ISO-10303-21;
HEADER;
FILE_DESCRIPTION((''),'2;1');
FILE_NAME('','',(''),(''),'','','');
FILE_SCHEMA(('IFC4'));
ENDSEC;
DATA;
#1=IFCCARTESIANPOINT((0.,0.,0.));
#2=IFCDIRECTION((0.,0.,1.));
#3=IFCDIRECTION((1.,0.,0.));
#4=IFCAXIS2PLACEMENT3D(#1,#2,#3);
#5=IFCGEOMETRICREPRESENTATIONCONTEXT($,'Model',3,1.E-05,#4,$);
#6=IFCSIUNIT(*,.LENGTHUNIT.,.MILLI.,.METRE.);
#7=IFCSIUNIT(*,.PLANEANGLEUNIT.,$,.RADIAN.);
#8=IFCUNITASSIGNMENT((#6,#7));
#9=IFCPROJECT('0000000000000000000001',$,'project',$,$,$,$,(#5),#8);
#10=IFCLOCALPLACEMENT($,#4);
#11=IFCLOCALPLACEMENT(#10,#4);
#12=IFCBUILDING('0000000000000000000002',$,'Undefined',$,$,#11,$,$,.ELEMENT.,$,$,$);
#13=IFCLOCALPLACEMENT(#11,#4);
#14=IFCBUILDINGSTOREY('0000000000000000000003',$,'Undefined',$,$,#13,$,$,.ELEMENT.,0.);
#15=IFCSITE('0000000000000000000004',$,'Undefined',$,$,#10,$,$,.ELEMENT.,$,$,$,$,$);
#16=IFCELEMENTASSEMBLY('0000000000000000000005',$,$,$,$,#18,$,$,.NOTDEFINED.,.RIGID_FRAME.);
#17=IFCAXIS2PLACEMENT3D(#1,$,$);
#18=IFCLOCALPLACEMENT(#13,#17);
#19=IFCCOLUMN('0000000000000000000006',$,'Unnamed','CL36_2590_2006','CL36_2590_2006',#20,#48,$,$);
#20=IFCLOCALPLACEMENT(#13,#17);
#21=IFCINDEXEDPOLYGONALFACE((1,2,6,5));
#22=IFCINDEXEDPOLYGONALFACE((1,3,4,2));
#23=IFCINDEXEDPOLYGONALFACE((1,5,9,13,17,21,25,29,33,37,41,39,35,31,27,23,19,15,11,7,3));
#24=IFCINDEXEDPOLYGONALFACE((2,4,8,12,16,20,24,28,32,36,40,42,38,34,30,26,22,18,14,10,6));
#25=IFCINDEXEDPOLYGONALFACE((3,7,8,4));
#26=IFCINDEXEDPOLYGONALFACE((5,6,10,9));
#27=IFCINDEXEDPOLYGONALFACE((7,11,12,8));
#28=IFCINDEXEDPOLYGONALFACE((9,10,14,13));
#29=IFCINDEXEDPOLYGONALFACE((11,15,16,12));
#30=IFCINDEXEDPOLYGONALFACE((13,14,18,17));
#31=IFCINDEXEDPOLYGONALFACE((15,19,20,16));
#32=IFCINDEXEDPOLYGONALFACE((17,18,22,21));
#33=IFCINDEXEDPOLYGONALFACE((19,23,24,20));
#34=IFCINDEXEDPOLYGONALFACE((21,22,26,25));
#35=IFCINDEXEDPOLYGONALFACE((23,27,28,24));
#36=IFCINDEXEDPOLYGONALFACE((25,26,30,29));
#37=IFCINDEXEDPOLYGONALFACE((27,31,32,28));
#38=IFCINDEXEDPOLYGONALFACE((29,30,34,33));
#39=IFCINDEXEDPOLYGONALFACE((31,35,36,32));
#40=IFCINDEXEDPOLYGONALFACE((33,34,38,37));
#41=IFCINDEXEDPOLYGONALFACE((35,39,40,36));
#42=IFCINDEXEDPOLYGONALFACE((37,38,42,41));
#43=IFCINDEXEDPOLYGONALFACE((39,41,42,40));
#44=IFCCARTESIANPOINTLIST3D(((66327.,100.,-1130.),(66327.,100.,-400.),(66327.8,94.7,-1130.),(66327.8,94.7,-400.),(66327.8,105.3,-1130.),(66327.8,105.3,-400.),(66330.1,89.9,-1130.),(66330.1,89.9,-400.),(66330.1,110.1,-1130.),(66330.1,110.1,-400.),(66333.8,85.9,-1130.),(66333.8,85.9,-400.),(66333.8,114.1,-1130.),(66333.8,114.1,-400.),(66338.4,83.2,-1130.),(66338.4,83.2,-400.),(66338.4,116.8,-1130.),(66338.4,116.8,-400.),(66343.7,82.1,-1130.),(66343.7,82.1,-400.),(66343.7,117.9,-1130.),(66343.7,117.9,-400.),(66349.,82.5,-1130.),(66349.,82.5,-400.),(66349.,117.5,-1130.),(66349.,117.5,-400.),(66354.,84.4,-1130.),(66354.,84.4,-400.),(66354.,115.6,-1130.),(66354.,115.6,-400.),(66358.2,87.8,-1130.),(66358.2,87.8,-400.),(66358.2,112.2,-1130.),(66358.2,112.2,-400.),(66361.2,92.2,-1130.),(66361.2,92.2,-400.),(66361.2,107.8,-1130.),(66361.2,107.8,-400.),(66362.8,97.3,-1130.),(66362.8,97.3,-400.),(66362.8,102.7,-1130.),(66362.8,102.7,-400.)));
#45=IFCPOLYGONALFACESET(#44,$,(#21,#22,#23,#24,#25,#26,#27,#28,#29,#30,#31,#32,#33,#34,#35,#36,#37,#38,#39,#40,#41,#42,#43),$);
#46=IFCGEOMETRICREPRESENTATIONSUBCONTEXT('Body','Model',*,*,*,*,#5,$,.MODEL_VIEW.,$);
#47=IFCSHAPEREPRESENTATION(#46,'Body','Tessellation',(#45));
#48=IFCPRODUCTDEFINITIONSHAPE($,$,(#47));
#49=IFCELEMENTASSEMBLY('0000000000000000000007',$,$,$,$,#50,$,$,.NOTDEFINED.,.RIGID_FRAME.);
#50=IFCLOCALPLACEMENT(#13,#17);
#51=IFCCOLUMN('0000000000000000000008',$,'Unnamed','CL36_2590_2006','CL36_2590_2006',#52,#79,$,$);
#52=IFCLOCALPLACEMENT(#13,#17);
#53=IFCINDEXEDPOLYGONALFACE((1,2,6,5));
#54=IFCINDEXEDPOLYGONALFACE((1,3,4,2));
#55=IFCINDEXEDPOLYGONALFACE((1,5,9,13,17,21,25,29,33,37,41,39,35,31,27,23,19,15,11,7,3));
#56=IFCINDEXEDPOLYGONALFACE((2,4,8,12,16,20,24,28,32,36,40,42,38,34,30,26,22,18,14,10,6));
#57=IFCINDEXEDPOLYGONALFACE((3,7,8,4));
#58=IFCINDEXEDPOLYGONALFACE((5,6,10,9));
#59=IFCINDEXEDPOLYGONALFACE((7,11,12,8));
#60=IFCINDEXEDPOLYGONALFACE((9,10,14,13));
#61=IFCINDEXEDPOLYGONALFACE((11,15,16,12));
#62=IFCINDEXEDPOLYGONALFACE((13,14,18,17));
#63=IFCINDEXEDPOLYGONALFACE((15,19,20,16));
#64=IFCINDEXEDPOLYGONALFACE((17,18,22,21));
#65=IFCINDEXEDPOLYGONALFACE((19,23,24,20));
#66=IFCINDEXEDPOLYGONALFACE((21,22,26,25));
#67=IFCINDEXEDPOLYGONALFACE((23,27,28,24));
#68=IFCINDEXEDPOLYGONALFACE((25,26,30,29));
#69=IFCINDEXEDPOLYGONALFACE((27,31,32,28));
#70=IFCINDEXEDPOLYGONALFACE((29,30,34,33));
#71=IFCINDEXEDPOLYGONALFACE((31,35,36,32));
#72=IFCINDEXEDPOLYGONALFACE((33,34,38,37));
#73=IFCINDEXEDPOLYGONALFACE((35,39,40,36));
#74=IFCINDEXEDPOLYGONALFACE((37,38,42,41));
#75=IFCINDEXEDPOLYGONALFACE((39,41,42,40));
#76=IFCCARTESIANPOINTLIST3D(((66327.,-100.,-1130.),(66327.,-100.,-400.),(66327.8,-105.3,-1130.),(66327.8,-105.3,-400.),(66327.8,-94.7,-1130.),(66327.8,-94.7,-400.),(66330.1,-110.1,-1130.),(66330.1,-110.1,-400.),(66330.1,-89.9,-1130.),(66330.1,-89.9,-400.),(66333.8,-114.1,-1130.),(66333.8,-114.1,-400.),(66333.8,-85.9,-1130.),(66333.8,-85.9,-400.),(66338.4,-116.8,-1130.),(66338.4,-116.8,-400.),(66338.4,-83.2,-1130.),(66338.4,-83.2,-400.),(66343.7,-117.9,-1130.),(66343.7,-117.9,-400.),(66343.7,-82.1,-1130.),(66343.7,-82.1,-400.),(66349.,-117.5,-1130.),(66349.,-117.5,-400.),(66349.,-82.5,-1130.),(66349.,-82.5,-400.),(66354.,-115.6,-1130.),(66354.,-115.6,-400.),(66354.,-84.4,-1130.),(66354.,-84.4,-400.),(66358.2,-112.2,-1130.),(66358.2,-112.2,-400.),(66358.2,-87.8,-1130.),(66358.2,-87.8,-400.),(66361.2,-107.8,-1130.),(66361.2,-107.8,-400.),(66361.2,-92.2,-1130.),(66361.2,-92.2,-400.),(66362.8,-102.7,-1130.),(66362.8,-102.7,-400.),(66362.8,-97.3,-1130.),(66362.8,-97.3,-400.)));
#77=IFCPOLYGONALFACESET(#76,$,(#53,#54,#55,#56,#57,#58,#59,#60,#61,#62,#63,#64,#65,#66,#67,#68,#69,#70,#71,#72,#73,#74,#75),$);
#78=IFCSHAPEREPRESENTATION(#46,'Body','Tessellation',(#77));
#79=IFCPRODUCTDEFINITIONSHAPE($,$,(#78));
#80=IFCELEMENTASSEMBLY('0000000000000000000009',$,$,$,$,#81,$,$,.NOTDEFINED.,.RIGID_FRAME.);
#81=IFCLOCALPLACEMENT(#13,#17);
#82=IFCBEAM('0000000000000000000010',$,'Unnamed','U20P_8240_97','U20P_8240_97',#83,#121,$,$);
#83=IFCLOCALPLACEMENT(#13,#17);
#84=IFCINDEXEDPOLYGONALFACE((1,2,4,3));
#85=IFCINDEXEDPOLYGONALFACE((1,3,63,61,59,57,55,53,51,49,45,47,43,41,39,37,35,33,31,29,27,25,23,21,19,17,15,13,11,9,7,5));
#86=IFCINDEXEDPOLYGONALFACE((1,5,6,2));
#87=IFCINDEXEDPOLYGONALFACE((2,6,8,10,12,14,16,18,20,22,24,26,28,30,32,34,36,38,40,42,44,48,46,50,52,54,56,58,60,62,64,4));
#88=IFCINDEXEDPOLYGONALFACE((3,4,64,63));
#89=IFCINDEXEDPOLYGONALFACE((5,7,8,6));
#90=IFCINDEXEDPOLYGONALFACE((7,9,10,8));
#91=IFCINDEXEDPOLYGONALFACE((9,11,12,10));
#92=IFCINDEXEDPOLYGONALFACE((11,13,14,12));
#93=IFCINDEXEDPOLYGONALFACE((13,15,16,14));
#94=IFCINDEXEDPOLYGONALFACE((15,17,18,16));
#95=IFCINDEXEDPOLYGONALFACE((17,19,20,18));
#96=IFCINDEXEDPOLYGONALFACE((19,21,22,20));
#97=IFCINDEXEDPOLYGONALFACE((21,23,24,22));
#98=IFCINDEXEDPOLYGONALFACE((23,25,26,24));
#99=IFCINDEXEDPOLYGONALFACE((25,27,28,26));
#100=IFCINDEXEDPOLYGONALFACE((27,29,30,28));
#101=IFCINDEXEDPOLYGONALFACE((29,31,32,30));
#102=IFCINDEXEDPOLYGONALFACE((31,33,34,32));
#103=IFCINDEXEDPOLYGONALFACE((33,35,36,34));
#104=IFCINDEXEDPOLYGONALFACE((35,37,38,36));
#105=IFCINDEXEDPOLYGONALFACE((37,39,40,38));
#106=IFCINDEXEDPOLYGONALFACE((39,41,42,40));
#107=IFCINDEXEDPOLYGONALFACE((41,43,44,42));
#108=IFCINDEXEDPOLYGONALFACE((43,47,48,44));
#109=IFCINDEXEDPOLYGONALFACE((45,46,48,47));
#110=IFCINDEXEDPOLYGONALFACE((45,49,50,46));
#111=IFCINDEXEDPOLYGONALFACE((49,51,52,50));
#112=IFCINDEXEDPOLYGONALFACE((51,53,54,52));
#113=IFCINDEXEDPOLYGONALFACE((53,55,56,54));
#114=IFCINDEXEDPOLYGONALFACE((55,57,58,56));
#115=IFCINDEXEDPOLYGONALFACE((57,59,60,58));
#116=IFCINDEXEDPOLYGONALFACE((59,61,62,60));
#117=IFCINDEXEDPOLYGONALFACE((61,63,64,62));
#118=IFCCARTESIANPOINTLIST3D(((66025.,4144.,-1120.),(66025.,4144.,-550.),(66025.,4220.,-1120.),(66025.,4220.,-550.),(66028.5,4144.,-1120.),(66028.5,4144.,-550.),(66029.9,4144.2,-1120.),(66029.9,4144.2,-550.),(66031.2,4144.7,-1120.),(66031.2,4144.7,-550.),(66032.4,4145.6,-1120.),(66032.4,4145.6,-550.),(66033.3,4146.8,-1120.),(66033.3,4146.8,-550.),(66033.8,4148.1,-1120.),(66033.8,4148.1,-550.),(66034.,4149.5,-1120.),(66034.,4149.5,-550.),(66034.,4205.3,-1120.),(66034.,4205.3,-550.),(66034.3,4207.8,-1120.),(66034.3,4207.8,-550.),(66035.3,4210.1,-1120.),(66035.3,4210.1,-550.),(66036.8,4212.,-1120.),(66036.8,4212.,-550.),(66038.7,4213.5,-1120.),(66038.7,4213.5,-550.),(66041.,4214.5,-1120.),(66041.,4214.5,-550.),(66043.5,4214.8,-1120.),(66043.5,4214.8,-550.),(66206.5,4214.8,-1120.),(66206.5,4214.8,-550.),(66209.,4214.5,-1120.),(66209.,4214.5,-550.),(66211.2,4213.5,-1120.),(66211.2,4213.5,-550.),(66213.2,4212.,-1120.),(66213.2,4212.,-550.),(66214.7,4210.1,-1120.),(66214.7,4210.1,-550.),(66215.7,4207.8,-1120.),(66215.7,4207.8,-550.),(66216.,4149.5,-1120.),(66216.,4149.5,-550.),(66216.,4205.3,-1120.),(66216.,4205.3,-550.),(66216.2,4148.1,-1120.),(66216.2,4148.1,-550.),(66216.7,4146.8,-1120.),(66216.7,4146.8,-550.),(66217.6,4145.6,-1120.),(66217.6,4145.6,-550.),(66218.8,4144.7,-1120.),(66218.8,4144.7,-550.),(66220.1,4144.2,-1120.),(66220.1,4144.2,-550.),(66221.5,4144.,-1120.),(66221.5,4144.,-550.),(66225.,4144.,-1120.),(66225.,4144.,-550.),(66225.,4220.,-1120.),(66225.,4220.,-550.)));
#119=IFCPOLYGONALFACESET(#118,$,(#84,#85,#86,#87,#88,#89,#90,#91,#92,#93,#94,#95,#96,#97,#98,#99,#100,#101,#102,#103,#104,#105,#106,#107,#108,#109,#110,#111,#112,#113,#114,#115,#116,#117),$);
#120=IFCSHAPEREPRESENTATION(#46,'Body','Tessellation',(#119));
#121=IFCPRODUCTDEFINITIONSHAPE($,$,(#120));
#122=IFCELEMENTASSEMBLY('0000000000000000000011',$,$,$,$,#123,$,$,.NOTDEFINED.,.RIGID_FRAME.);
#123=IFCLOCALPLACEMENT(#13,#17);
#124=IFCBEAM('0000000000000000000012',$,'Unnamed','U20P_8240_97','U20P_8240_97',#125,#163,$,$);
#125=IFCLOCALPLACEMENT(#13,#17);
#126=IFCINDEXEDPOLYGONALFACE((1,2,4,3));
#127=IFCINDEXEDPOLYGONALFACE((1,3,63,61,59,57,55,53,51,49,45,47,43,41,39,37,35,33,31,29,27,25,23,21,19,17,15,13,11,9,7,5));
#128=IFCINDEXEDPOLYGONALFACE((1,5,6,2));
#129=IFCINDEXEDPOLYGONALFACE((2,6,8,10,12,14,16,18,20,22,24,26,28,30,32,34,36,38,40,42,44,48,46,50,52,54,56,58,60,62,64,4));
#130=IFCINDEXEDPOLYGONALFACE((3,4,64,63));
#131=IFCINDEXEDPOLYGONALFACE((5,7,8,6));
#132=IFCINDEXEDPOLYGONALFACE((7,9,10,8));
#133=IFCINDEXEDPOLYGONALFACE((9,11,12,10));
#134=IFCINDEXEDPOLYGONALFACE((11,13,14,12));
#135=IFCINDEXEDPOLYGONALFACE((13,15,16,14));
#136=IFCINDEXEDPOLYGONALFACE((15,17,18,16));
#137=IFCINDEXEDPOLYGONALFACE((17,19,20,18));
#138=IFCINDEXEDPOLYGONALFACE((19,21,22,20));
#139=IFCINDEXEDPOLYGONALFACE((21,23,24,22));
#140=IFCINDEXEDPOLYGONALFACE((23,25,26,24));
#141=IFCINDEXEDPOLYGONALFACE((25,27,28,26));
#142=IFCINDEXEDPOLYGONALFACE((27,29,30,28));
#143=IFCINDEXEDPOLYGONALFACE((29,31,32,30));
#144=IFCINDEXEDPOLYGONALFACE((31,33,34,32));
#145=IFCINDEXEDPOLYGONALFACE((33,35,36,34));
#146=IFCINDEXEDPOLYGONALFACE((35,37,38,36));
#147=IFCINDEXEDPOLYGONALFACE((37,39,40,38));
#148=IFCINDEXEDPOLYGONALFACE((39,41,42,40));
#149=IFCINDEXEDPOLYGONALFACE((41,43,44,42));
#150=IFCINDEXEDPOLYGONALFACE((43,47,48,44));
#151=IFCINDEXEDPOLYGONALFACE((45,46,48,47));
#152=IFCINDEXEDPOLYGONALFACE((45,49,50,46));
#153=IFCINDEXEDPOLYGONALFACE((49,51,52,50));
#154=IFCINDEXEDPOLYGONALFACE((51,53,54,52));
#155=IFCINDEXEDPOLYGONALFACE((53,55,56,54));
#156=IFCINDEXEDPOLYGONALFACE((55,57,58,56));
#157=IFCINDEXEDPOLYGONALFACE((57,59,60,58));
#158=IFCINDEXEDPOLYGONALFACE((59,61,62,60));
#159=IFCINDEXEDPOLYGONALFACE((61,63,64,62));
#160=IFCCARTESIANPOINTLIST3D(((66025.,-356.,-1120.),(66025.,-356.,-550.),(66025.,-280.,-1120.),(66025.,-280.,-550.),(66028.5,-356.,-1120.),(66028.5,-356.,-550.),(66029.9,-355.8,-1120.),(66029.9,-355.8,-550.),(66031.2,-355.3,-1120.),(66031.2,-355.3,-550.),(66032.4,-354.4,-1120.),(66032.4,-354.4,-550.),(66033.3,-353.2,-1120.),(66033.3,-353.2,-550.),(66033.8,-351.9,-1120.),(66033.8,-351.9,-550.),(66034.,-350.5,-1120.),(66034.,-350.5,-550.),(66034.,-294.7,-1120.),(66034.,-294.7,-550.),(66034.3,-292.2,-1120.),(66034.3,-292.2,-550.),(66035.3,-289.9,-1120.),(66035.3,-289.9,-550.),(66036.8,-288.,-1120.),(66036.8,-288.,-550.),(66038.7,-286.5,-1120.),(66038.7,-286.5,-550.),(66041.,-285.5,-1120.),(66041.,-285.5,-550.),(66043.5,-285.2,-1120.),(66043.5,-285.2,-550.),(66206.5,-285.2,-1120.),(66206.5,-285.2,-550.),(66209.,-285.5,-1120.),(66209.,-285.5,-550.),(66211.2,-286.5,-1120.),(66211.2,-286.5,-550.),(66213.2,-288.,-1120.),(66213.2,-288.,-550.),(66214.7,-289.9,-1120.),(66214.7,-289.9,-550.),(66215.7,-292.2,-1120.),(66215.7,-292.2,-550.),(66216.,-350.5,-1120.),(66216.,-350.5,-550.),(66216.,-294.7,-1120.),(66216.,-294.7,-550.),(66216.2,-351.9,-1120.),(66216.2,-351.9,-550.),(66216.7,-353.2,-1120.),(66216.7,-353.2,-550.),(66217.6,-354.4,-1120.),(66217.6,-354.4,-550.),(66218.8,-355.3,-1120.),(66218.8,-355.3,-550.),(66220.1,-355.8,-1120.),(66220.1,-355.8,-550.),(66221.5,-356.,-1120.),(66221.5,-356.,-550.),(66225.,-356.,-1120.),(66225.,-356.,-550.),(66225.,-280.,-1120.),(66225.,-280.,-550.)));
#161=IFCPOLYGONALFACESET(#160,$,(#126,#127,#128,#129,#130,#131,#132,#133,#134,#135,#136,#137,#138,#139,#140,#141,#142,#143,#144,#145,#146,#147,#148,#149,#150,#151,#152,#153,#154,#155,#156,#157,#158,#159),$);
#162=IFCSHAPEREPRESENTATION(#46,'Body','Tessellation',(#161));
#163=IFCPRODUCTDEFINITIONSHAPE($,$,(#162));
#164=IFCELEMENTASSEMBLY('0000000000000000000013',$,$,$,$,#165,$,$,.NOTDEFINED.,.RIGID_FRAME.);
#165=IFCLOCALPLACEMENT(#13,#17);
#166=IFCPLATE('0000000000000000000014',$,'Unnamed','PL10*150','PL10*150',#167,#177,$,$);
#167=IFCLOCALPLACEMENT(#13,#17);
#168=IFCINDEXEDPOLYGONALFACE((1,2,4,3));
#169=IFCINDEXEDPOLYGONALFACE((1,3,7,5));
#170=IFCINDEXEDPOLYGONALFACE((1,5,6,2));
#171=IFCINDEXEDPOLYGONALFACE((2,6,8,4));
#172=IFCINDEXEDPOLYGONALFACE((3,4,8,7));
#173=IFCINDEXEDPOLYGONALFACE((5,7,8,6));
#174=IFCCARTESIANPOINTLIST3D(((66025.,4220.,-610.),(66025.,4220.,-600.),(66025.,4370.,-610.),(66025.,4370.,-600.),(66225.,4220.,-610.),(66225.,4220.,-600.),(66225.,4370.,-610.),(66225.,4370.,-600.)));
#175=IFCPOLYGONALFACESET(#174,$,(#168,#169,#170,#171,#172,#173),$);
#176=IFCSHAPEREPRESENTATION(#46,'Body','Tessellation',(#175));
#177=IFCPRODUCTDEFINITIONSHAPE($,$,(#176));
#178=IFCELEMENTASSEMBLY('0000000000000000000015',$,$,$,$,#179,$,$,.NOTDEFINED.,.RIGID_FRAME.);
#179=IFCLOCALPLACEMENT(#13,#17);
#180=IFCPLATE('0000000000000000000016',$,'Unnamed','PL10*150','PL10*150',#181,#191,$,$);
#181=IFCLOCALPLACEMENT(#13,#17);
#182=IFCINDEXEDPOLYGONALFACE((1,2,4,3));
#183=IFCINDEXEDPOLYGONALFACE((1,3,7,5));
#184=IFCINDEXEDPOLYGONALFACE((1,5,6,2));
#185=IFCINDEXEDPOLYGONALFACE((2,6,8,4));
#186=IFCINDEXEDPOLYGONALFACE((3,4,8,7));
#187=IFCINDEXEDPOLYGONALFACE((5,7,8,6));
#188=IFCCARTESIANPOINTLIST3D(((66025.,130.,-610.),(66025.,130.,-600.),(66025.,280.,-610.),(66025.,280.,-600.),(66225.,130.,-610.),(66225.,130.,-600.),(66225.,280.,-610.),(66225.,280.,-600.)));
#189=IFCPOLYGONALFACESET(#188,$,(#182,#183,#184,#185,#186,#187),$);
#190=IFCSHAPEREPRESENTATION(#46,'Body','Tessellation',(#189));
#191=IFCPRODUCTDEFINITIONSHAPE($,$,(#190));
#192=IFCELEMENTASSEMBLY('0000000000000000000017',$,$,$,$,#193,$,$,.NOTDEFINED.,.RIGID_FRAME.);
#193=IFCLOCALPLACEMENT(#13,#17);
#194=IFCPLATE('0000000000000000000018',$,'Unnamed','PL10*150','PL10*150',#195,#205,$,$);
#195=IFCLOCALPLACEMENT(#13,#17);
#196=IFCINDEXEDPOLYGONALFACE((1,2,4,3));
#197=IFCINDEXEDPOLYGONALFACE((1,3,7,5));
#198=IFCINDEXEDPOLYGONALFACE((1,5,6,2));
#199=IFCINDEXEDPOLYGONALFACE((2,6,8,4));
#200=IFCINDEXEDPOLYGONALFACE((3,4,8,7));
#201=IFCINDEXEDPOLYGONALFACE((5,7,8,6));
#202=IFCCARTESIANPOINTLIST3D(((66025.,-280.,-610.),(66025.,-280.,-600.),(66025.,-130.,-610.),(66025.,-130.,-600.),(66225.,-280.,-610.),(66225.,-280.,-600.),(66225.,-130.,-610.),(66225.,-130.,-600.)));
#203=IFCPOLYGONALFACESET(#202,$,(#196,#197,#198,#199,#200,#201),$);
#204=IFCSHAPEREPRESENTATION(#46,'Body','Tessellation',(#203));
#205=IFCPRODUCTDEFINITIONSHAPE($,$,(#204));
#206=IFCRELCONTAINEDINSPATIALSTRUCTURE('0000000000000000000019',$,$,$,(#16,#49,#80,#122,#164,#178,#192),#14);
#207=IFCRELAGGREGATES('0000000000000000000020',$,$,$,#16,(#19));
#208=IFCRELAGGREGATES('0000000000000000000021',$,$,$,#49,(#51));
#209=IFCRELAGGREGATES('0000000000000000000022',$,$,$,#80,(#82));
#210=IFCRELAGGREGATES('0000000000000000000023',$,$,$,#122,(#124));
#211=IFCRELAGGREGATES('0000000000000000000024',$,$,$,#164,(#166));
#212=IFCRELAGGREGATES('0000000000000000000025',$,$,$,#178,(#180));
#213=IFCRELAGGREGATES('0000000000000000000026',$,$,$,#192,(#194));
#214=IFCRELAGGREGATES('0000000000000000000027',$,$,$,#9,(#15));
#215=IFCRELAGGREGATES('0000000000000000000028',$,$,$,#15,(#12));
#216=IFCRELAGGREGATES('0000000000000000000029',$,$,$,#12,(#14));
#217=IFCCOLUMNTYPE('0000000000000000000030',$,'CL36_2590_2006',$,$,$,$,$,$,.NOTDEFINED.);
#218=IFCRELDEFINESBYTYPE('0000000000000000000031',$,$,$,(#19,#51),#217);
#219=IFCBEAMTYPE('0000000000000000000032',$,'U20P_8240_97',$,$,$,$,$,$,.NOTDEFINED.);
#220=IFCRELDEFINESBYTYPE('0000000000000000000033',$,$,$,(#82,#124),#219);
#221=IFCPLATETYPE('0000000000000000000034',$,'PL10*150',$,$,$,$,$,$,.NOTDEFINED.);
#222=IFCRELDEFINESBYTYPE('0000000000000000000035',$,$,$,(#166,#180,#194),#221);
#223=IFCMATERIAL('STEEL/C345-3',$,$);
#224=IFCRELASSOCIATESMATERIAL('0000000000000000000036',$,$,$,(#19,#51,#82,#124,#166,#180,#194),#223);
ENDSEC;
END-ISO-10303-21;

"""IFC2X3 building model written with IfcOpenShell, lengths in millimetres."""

from ifc_helpers import new_model, si_unit, frame, origin_with_axes, origin_2d_with_axis, place, context, subcontext, project, spatial, polyline, circle, u_section, outline, extrude, material, type_object, element, aggregate, save


model = new_model("IFC2X3")

# Units and contexts
model_context = context("Model", 3, precision=1e-05, world=origin_with_axes())
body_context = subcontext(model_context, "Body", "Model", "MODEL_VIEW")
ifc_project = project(units=[si_unit("LENGTHUNIT", "METRE", prefix="MILLI"), si_unit("PLANEANGLEUNIT", "RADIAN")], contexts=[model_context])

# Site, building, storey
site_placement = place(None, origin_with_axes())
site = spatial("IfcSite", under=ifc_project, at=site_placement, Name="Undefined", CompositionType="ELEMENT")
building_placement = place(site_placement, origin_with_axes())
building = spatial("IfcBuilding", under=site, at=building_placement, Name="Undefined", CompositionType="ELEMENT")
storey_placement = place(building_placement, origin_with_axes())
storey = spatial("IfcBuildingStorey", under=building, at=storey_placement, Name="Undefined", CompositionType="ELEMENT", Elevation=0.0)

# Element assemblies, columns
ifc_material_1 = material(Name="STEEL/C345-3")
column_type_1 = type_object("IfcColumnType", Name="CL36_2590_2006", PredefinedType="NOTDEFINED")
assembly_1_placement = place(storey_placement, origin_with_axes())
assembly_1 = element("IfcElementAssembly", 1, at=assembly_1_placement, inside=storey, AssemblyPlace="NOTDEFINED", PredefinedType="RIGID_FRAME")
column_1_placement = place(assembly_1_placement, frame((66345.0, 100.0, -1130.0), z_axis=(0.0, 0.0, 1.0), x_axis=(0.0, 1.0, 0.0)))
column_1 = element("IfcColumn", 2, at=column_1_placement, type_object=column_type_1, material=ifc_material_1, Name="Unnamed", Description="CL36_2590_2006", ObjectType="CL36_2590_2006", context=body_context, shape_type="SweptSolid", body=[
    extrude(circle(Radius=18.0, at=origin_2d_with_axis()), frame((0.0, 0.0, 730.0), z_axis=(0.0, 0.0, -1.0), x_axis=(0.0, 1.0, 0.0)), (0.0, 0.0, 1.0), 730.0),
])
aggregate(assembly_1, [column_1])
assembly_2_placement = place(storey_placement, origin_with_axes())
assembly_2 = element("IfcElementAssembly", 3, at=assembly_2_placement, inside=storey, AssemblyPlace="NOTDEFINED", PredefinedType="RIGID_FRAME")
column_2_placement = place(assembly_2_placement, frame((66345.0, -100.0, -1130.0), z_axis=(0.0, 0.0, 1.0), x_axis=(0.0, 1.0, 0.0)))
column_2 = element("IfcColumn", 4, at=column_2_placement, type_object=column_type_1, material=ifc_material_1, Name="Unnamed", Description="CL36_2590_2006", ObjectType="CL36_2590_2006", context=body_context, shape_type="SweptSolid", body=[
    extrude(circle(Radius=18.0, at=origin_2d_with_axis()), frame((0.0, 0.0, 730.0), z_axis=(0.0, 0.0, -1.0), x_axis=(0.0, 1.0, 0.0)), (0.0, 0.0, 1.0), 730.0),
])
aggregate(assembly_2, [column_2])

# Element assemblies, beams
assembly_3_placement = place(storey_placement, origin_with_axes())
assembly_3 = element("IfcElementAssembly", 5, at=assembly_3_placement, inside=storey, AssemblyPlace="NOTDEFINED", PredefinedType="RIGID_FRAME")
beam_type = type_object("IfcBeamType", Name="U20P_8240_97", PredefinedType="NOTDEFINED")
beam_1_placement = place(assembly_3_placement, frame((66125.0, 4182.0, -550.0), z_axis=(1.0, 0.0, 0.0), x_axis=(0.0, 0.0, -1.0)))
beam_1 = element("IfcBeam", 6, at=beam_1_placement, type_object=beam_type, material=ifc_material_1, Name="Unnamed", Description="U20P_8240_97", ObjectType="U20P_8240_97", context=body_context, shape_type="SweptSolid", body=[
    extrude(u_section(Depth=200.0, FlangeWidth=76.0, WebThickness=5.2, FlangeThickness=9.0, FilletRadius=9.5, EdgeRadius=5.5, at=origin_2d_with_axis()), frame((570.0, 0.0, 0.0), z_axis=(-1.0, 0.0, 0.0), x_axis=(0.0, -1.0, 0.0)), (0.0, 0.0, 1.0), 570.0),
])
aggregate(assembly_3, [beam_1])
assembly_4_placement = place(storey_placement, origin_with_axes())
assembly_4 = element("IfcElementAssembly", 7, at=assembly_4_placement, inside=storey, AssemblyPlace="NOTDEFINED", PredefinedType="RIGID_FRAME")
beam_2_placement = place(assembly_4_placement, frame((66125.0, -318.0, -550.0), z_axis=(1.0, 0.0, 0.0), x_axis=(0.0, 0.0, -1.0)))
beam_2 = element("IfcBeam", 8, at=beam_2_placement, type_object=beam_type, material=ifc_material_1, Name="Unnamed", Description="U20P_8240_97", ObjectType="U20P_8240_97", context=body_context, shape_type="SweptSolid", body=[
    extrude(u_section(Depth=200.0, FlangeWidth=76.0, WebThickness=5.2, FlangeThickness=9.0, FilletRadius=9.5, EdgeRadius=5.5, at=origin_2d_with_axis()), frame((570.0, 0.0, 0.0), z_axis=(-1.0, 0.0, 0.0), x_axis=(0.0, -1.0, 0.0)), (0.0, 0.0, 1.0), 570.0),
])
aggregate(assembly_4, [beam_2])

# Element assemblies, plates
assembly_5_placement = place(storey_placement, origin_with_axes())
assembly_5 = element("IfcElementAssembly", 9, at=assembly_5_placement, inside=storey, AssemblyPlace="NOTDEFINED", PredefinedType="RIGID_FRAME")
plate_type_1 = type_object("IfcPlateType", Name="PL10*150", PredefinedType="NOTDEFINED")
plate_1_placement = place(assembly_5_placement, frame((66025.0, 4370.0, -605.0), z_axis=(0.0, 0.0, 1.0), x_axis=(0.0, -1.0, 0.0)))
plate_1 = element("IfcPlate", 10, at=plate_1_placement, type_object=plate_type_1, material=ifc_material_1, Name="Unnamed", Description="PL10*150", ObjectType="PL10*150", context=body_context, shape_type="SweptSolid", body=[
    extrude(outline(polyline([(0.0, 0.0), (150.0, 0.0), (150.0, 200.0), (0.0, 200.0), (0.0, 0.0)])), frame((0.0, 0.0, -5.0), z_axis=(0.0, 0.0, 1.0), x_axis=(1.0, 0.0, 0.0)), (0.0, 0.0, 1.0), 10.0),
])
aggregate(assembly_5, [plate_1])
assembly_6_placement = place(storey_placement, origin_with_axes())
assembly_6 = element("IfcElementAssembly", 11, at=assembly_6_placement, inside=storey, AssemblyPlace="NOTDEFINED", PredefinedType="RIGID_FRAME")
plate_2_placement = place(assembly_6_placement, frame((66025.0, 130.0, -605.0), z_axis=(0.0, 0.0, -1.0), x_axis=(0.0, 1.0, 0.0)))
plate_2 = element("IfcPlate", 12, at=plate_2_placement, type_object=plate_type_1, material=ifc_material_1, Name="Unnamed", Description="PL10*150", ObjectType="PL10*150", context=body_context, shape_type="SweptSolid", body=[
    extrude(outline(polyline([(0.0, 0.0), (150.0, 0.0), (150.0, 200.0), (0.0, 200.0), (0.0, 0.0)])), frame((0.0, 0.0, -5.0), z_axis=(0.0, 0.0, 1.0), x_axis=(1.0, 0.0, 0.0)), (0.0, 0.0, 1.0), 10.0),
])
aggregate(assembly_6, [plate_2])
assembly_7_placement = place(storey_placement, origin_with_axes())
assembly_7 = element("IfcElementAssembly", 13, at=assembly_7_placement, inside=storey, AssemblyPlace="NOTDEFINED", PredefinedType="RIGID_FRAME")
plate_3_placement = place(assembly_7_placement, frame((66025.0, -130.0, -605.0), z_axis=(0.0, 0.0, 1.0), x_axis=(0.0, -1.0, 0.0)))
plate_3 = element("IfcPlate", 14, at=plate_3_placement, type_object=plate_type_1, material=ifc_material_1, Name="Unnamed", Description="PL10*150", ObjectType="PL10*150", context=body_context, shape_type="SweptSolid", body=[
    extrude(outline(polyline([(0.0, 0.0), (150.0, 0.0), (150.0, 200.0), (0.0, 200.0), (0.0, 0.0)])), frame((0.0, 0.0, -5.0), z_axis=(0.0, 0.0, 1.0), x_axis=(1.0, 0.0, 0.0)), (0.0, 0.0, 1.0), 10.0),
])
aggregate(assembly_7, [plate_3])

save(model, "model.ifc")
